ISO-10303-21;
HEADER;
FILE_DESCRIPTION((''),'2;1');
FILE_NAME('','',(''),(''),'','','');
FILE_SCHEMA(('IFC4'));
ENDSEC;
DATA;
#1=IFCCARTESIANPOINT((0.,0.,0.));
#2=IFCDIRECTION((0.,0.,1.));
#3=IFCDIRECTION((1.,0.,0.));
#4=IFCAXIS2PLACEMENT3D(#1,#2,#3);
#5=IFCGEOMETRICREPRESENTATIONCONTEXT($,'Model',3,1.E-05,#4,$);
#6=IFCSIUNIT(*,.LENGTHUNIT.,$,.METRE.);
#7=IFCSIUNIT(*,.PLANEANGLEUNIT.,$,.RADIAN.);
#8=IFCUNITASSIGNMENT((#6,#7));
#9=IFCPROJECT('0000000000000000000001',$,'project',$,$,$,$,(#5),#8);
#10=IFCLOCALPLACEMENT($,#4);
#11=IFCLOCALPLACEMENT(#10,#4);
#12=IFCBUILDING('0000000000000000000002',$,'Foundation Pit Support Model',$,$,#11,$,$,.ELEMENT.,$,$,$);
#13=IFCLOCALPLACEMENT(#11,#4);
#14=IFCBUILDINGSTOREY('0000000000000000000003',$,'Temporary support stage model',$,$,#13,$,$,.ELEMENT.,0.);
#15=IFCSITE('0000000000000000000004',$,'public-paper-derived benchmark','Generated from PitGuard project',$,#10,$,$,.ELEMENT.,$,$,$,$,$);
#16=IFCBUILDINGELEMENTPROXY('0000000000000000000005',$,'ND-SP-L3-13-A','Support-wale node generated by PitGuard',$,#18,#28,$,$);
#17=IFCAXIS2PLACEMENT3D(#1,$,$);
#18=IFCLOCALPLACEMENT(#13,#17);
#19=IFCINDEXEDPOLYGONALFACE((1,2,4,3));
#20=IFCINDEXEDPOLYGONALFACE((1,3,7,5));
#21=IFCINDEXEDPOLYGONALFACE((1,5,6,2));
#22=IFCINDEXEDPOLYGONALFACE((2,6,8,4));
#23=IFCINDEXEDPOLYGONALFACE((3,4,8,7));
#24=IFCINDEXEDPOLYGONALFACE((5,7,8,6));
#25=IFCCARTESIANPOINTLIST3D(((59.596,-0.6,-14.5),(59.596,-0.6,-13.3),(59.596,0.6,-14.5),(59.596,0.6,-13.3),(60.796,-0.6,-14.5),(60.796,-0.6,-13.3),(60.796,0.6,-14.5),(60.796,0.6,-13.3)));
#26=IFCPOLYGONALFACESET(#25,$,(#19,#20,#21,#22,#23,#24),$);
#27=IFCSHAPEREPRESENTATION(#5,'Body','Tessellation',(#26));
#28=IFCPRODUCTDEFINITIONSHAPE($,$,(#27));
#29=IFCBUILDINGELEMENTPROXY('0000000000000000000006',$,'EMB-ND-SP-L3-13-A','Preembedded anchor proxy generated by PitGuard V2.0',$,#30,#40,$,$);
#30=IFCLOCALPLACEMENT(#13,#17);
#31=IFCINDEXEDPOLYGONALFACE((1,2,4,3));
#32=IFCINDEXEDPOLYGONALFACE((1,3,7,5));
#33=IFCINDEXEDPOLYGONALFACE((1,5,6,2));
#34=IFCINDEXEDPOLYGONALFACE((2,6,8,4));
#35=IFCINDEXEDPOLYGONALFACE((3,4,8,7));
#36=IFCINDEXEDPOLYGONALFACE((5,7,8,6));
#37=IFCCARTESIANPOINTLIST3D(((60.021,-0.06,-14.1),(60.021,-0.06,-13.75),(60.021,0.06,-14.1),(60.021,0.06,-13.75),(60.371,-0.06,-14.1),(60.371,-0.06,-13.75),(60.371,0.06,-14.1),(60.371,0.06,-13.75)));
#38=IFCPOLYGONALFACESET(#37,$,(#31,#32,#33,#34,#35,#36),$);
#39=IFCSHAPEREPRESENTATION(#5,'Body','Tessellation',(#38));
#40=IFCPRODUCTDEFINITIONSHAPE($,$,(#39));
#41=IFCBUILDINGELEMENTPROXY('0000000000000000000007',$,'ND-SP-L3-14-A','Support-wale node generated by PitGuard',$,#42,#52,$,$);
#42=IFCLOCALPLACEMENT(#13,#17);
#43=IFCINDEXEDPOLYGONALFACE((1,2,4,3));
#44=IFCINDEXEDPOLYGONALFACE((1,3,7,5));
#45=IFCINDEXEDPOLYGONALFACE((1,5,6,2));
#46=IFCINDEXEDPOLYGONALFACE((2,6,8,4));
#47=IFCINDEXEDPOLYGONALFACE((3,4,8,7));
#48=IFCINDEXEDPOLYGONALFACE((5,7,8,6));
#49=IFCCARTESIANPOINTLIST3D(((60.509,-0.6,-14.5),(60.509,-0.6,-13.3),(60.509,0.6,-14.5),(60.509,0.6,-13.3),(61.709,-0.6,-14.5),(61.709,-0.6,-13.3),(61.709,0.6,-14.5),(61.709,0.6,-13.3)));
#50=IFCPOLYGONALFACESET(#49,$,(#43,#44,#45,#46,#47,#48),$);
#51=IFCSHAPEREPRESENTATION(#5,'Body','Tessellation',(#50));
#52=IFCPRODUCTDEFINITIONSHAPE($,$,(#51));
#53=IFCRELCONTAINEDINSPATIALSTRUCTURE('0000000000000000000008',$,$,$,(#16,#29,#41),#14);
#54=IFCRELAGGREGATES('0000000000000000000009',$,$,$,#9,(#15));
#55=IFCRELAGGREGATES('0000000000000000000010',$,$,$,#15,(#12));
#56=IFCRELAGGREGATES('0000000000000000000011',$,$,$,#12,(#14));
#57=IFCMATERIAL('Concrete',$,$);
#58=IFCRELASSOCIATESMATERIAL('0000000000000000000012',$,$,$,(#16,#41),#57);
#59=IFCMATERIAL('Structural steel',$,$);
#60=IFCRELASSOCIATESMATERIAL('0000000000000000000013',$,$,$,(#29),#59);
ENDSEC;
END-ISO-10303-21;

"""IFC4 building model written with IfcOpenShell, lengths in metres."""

from ifc_helpers import new_model, si_unit, frame, origin_with_axes, origin_2d, place, context, project, spatial, rectangle, extrude, material, element, save


model = new_model("IFC4")

# Units and contexts
model_context = context("Model", 3, precision=1e-05, world=origin_with_axes())
ifc_project = project(units=[si_unit("LENGTHUNIT", "METRE"), si_unit("PLANEANGLEUNIT", "RADIAN")], contexts=[model_context])

# Site, building, storey
site_placement = place(None, origin_with_axes())
site = spatial("IfcSite", under=ifc_project, at=site_placement, Name="public-paper-derived benchmark", Description="Generated from PitGuard project", CompositionType="ELEMENT")
building_placement = place(site_placement, origin_with_axes())
building = spatial("IfcBuilding", under=site, at=building_placement, Name="Foundation Pit Support Model", CompositionType="ELEMENT")
storey_placement = place(building_placement, origin_with_axes())
storey = spatial("IfcBuildingStorey", under=building, at=storey_placement, Name="Temporary support stage model", CompositionType="ELEMENT", Elevation=0.0)

# Shared definitions
ifc_material_1 = material(Name="Concrete")

# Shared definitions
ifc_material_2 = material(Name="Structural steel")

# Building element proxies
proxy_1_placement = place(storey_placement, frame((60.196, 0.0, -14.5), z_axis=(0.0, 0.0, 1.0), x_axis=(1.0, 0.0, 0.0)))
element("IfcBuildingElementProxy", 1, at=proxy_1_placement, inside=storey, material=ifc_material_1, Name="ND-SP-L3-13-A", Description="Support-wale node generated by PitGuard", context=model_context, shape_type="SweptSolid", body=[
    extrude(rectangle(XDim=1.2, YDim=1.2, at=origin_2d()), origin_with_axes(), (0.0, 0.0, 1.0), 1.2),
])
proxy_2_placement = place(storey_placement, frame((60.196, 0.0, -14.1), z_axis=(0.0, 0.0, 1.0), x_axis=(1.0, 0.0, 0.0)))
element("IfcBuildingElementProxy", 2, at=proxy_2_placement, inside=storey, material=ifc_material_2, Name="EMB-ND-SP-L3-13-A", Description="Preembedded anchor proxy generated by PitGuard V2.0", context=model_context, shape_type="SweptSolid", body=[
    extrude(rectangle(XDim=0.35, YDim=0.12, at=origin_2d()), origin_with_axes(), (0.0, 0.0, 1.0), 0.35),
])
proxy_3_placement = place(storey_placement, frame((61.109, 0.0, -14.5), z_axis=(0.0, 0.0, 1.0), x_axis=(1.0, 0.0, 0.0)))
element("IfcBuildingElementProxy", 3, at=proxy_3_placement, inside=storey, material=ifc_material_1, Name="ND-SP-L3-14-A", Description="Support-wale node generated by PitGuard", context=model_context, shape_type="SweptSolid", body=[
    extrude(rectangle(XDim=1.2, YDim=1.2, at=origin_2d()), origin_with_axes(), (0.0, 0.0, 1.0), 1.2),
])

save(model, "model.ifc")
